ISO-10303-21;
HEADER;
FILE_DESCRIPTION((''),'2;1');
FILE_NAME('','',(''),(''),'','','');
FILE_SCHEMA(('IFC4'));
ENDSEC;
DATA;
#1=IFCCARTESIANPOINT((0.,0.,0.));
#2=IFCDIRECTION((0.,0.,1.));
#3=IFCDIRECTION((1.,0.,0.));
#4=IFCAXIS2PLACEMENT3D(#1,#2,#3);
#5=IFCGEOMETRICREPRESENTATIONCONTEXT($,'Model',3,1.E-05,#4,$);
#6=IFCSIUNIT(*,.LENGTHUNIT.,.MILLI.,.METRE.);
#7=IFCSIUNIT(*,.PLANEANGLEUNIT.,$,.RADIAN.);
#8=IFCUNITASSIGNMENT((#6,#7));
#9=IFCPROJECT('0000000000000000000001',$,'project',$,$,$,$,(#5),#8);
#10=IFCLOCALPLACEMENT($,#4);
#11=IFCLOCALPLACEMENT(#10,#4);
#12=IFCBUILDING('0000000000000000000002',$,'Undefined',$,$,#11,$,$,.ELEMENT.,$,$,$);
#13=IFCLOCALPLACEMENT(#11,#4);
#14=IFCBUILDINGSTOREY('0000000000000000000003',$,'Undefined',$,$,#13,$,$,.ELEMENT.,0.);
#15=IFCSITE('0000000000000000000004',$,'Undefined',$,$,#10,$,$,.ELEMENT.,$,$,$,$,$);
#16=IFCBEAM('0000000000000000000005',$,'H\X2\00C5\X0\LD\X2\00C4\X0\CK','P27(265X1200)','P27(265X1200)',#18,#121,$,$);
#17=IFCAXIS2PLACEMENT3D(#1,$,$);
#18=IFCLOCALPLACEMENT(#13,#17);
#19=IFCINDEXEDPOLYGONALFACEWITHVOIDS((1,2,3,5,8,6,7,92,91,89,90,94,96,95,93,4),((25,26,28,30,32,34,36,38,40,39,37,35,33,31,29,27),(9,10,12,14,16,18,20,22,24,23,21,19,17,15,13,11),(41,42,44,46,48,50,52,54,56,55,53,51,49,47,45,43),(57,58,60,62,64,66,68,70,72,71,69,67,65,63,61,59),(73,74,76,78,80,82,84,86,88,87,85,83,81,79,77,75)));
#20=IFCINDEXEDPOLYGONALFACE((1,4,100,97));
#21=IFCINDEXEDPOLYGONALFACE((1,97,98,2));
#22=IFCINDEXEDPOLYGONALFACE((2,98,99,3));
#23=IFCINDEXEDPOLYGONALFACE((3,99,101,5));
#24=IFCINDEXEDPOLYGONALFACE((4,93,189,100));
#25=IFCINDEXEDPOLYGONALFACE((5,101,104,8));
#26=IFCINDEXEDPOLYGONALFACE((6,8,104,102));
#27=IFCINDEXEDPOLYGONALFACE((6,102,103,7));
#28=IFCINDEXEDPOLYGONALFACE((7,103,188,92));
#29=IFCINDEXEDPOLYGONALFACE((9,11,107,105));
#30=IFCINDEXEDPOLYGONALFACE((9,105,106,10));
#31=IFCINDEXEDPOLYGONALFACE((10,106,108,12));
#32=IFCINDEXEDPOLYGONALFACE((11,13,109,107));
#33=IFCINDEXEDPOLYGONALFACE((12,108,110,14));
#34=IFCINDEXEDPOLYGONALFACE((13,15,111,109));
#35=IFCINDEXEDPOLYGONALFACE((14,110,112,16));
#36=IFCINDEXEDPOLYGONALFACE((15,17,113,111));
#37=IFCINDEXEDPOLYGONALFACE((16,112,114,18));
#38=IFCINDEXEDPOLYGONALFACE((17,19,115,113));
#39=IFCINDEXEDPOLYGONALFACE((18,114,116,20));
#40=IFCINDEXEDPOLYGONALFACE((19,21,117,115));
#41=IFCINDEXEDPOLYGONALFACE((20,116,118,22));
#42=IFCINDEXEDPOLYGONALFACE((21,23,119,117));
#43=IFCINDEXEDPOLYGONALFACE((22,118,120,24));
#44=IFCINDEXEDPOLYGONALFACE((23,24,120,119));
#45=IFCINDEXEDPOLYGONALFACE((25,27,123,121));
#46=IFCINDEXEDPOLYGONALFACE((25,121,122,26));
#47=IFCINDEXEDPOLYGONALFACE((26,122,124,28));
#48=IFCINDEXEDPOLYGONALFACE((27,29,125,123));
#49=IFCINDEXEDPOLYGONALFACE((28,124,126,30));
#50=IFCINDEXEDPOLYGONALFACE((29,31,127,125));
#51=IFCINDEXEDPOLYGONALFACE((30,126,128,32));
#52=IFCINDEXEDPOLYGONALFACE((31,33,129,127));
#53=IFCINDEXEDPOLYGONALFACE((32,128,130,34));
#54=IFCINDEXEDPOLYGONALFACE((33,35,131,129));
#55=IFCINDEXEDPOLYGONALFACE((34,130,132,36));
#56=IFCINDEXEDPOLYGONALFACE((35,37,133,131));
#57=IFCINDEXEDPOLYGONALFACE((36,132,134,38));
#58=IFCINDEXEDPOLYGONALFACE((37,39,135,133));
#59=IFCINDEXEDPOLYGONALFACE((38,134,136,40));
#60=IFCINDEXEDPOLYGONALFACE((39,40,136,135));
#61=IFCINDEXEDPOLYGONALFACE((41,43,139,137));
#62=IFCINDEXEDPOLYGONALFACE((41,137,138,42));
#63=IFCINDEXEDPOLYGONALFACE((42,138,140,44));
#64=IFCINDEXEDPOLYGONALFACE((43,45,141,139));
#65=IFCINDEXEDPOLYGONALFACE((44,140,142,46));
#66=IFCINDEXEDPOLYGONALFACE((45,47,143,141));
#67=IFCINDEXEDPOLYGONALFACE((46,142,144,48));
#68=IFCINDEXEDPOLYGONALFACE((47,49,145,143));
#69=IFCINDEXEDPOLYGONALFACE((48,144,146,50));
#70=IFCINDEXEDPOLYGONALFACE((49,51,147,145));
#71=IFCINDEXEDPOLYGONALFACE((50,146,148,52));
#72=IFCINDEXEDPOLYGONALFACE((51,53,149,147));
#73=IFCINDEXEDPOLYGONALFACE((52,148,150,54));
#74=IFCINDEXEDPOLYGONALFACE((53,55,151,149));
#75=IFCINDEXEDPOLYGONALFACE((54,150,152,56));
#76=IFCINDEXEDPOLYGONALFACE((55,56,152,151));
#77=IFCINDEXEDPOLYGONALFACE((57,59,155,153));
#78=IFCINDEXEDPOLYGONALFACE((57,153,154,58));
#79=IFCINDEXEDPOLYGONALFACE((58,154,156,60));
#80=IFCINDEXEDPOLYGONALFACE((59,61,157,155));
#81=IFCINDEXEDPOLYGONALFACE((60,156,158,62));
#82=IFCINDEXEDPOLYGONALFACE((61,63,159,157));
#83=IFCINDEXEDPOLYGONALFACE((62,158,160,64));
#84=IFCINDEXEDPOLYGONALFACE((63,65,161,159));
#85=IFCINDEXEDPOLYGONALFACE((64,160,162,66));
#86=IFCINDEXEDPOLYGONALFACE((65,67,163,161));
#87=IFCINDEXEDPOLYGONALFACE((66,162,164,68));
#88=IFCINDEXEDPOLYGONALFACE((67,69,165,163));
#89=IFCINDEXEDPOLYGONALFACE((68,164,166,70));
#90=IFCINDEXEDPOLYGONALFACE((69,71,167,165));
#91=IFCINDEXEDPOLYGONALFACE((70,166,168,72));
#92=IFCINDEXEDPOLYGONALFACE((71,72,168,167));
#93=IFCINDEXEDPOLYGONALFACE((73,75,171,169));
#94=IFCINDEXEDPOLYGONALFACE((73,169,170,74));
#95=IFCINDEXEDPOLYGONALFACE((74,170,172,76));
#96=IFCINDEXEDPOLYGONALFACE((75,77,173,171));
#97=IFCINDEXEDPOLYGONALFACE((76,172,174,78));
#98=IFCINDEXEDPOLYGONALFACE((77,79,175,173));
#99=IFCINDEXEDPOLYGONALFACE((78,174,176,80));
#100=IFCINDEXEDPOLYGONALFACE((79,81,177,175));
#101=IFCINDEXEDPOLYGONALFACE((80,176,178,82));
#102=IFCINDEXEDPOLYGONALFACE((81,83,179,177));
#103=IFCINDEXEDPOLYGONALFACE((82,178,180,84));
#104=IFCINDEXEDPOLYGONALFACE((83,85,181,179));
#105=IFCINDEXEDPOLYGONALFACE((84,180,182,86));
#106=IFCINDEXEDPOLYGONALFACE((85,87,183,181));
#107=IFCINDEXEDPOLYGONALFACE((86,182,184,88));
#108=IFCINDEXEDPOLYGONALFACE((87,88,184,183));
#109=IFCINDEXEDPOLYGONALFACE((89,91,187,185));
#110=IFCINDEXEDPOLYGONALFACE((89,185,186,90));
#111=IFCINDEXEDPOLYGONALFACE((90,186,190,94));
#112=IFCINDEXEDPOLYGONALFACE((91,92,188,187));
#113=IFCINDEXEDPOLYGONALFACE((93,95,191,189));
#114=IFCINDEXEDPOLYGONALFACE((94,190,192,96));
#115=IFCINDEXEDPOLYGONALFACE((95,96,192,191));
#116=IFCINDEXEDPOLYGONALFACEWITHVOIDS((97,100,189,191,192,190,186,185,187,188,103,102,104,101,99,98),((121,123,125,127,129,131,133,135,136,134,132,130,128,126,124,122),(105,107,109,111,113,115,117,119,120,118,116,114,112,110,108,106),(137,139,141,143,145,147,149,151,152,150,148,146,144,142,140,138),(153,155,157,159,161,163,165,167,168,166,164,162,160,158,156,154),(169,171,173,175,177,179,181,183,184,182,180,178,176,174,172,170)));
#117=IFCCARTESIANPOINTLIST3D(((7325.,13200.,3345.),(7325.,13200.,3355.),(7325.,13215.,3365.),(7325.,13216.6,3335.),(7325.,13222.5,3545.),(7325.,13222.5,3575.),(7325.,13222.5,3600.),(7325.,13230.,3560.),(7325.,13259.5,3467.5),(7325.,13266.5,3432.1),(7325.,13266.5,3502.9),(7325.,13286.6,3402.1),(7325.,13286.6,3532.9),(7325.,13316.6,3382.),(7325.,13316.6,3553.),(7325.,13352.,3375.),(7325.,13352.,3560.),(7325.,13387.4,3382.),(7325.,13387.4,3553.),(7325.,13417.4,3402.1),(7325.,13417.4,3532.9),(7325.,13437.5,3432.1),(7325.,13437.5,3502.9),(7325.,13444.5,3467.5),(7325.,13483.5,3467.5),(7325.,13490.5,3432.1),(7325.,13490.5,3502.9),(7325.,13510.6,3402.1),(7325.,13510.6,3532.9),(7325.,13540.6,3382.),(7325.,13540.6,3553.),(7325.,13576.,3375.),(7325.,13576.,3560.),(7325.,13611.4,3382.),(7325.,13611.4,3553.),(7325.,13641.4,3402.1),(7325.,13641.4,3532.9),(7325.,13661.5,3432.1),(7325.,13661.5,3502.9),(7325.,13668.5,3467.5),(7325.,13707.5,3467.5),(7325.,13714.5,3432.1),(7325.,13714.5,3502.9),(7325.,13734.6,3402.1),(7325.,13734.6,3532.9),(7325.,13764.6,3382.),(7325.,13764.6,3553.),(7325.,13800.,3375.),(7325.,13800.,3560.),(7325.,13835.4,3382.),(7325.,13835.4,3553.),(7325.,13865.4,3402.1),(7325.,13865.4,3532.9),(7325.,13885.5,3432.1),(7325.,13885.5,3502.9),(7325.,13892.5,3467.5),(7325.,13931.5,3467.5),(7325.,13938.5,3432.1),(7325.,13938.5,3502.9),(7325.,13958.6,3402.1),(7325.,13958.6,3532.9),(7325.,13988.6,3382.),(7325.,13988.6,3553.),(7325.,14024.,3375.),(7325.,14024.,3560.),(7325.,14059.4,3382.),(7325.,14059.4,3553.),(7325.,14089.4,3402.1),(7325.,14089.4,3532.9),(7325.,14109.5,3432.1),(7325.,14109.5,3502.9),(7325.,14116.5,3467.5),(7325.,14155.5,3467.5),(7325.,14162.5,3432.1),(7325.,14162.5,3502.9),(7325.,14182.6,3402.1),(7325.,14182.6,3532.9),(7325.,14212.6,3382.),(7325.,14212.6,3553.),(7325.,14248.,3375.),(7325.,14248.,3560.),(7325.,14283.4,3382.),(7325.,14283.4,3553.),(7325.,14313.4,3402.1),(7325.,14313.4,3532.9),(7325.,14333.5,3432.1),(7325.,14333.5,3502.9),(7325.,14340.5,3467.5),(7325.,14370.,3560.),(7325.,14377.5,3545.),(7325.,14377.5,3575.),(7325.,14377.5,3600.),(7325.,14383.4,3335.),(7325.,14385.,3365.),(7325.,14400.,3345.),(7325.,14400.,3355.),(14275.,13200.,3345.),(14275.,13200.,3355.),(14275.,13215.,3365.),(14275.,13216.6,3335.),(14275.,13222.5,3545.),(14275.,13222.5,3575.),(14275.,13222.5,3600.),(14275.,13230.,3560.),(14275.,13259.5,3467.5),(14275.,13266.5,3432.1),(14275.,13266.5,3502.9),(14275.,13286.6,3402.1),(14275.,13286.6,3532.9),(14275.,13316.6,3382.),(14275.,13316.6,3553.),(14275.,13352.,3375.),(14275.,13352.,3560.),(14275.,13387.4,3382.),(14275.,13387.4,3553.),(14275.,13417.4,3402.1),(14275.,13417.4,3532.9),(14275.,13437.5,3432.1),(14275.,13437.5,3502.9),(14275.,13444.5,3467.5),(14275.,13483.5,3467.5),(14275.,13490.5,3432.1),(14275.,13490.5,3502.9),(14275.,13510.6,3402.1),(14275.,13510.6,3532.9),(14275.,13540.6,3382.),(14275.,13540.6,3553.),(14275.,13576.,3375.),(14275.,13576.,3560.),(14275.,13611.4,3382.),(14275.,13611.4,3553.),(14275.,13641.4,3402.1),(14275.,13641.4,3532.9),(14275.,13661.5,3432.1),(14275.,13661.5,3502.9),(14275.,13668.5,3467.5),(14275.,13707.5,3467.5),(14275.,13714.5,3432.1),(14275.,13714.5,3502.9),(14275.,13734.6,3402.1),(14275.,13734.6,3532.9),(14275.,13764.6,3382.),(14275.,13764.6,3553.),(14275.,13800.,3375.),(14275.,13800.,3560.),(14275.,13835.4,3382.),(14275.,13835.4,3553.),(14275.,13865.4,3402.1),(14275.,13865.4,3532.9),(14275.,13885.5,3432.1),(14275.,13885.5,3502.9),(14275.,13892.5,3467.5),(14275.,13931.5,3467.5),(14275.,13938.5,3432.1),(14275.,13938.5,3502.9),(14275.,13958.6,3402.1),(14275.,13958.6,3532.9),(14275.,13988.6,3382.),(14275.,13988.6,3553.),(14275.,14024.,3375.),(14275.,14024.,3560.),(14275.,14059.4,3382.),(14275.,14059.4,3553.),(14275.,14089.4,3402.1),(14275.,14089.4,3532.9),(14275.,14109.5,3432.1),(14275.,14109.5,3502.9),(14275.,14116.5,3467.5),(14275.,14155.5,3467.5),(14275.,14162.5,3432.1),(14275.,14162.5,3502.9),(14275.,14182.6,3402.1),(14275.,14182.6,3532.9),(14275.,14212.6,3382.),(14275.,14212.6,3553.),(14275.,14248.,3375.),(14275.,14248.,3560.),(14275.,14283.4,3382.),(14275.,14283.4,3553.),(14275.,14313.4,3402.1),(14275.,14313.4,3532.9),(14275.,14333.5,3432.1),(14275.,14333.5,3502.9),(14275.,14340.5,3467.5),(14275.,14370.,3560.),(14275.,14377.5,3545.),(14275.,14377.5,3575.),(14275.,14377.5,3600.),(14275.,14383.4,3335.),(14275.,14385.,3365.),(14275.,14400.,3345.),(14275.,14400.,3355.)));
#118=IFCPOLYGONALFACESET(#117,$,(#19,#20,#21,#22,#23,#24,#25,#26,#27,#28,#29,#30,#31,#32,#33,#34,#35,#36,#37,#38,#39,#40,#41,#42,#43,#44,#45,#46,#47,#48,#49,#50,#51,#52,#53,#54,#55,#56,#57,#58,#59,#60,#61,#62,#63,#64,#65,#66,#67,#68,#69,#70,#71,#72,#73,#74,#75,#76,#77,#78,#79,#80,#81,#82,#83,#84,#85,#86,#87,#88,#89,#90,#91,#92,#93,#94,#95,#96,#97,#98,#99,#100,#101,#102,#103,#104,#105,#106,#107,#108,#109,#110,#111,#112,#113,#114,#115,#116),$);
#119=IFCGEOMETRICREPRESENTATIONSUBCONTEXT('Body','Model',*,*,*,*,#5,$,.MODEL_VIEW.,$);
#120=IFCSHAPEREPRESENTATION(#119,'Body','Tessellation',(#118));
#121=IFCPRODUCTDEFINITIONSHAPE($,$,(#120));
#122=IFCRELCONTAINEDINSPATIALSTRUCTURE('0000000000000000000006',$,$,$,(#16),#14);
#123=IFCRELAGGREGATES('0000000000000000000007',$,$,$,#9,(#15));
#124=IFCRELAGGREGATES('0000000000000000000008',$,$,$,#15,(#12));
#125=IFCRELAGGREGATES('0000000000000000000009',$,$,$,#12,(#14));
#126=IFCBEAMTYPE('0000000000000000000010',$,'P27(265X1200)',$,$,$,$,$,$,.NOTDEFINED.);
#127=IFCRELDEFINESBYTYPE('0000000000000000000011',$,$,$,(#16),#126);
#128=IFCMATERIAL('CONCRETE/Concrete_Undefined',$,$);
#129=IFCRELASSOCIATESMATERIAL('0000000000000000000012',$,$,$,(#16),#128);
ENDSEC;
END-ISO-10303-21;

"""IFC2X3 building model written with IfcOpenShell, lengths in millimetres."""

from ifc_helpers import new_model, si_unit, frame, origin_with_axes, place, context, subcontext, project, spatial, polyline, outline, extrude, material, type_object, element, save


model = new_model("IFC2X3")

# Units and contexts
model_context = context("Model", 3, precision=1e-05, world=origin_with_axes())
body_context = subcontext(model_context, "Body", "Model", "MODEL_VIEW")
ifc_project = project(units=[si_unit("LENGTHUNIT", "METRE", prefix="MILLI"), si_unit("PLANEANGLEUNIT", "RADIAN")], contexts=[model_context])

# Site, building, storey
site_placement = place(None, origin_with_axes())
site = spatial("IfcSite", under=ifc_project, at=site_placement, Name="Undefined", CompositionType="ELEMENT")
building_placement = place(site_placement, origin_with_axes())
building = spatial("IfcBuilding", under=site, at=building_placement, Name="Undefined", CompositionType="ELEMENT")
storey_placement = place(building_placement, origin_with_axes())
storey = spatial("IfcBuildingStorey", under=building, at=storey_placement, Name="Undefined", CompositionType="ELEMENT", Elevation=0.0)

# Beam
ifc_material_1 = material(Name="CONCRETE/Concrete_Undefined")
beam_type_1 = type_object("IfcBeamType", Name="P27(265X1200)", PredefinedType="NOTDEFINED")
beam_1_placement = place(storey_placement, frame((7325.0, 13800.0, 3467.5), z_axis=(0.0, 0.0, 1.0), x_axis=(1.0, 0.0, 0.0)))
element("IfcBeam", 1, at=beam_1_placement, inside=storey, type_object=beam_type_1, material=ifc_material_1, Name="HÅLDÄCK", Description="P27(265X1200)", ObjectType="P27(265X1200)", context=body_context, shape_type="SweptSolid", body=[
    extrude(outline(polyline([(-583.4, -132.5), (-600.0, -122.5), (-600.0, -112.5), (-585.0, -102.5), (-577.5, 77.5), (-570.0, 92.5), (-577.5, 107.5), (-577.5, 132.5), (577.5, 132.5), (577.5, 107.5), (570.0, 92.5), (577.5, 77.5), (585.0, -102.5), (600.0, -112.5), (600.0, -122.5), (583.4, -132.5), (-583.4, -132.5)]), holes=[polyline([(-513.4, 65.4), (-533.5, 35.4), (-540.5, 0.0), (-533.5, -35.4), (-513.4, -65.4), (-483.4, -85.5), (-448.0, -92.5), (-412.6, -85.5), (-382.6, -65.4), (-362.5, -35.4), (-355.5, 0.0), (-362.5, 35.4), (-382.6, 65.4), (-412.6, 85.5), (-448.0, 92.5), (-483.4, 85.5), (-513.4, 65.4)]), polyline([(-289.4, 65.4), (-309.5, 35.4), (-316.5, 0.0), (-309.5, -35.4), (-289.4, -65.4), (-259.4, -85.5), (-224.0, -92.5), (-188.6, -85.5), (-158.6, -65.4), (-138.5, -35.4), (-131.5, 0.0), (-138.5, 35.4), (-158.6, 65.4), (-188.6, 85.5), (-224.0, 92.5), (-259.4, 85.5), (-289.4, 65.4)]), polyline([(-65.4, 65.4), (-85.5, 35.4), (-92.5, 0.0), (-85.5, -35.4), (-65.4, -65.4), (-35.4, -85.5), (0.0, -92.5), (35.4, -85.5), (65.4, -65.4), (85.5, -35.4), (92.5, 0.0), (85.5, 35.4), (65.4, 65.4), (35.4, 85.5), (0.0, 92.5), (-35.4, 85.5), (-65.4, 65.4)]), polyline([(158.6, 65.4), (138.5, 35.4), (131.5, 0.0), (138.5, -35.4), (158.6, -65.4), (188.6, -85.5), (224.0, -92.5), (259.4, -85.5), (289.4, -65.4), (309.5, -35.4), (316.5, 0.0), (309.5, 35.4), (289.4, 65.4), (259.4, 85.5), (224.0, 92.5), (188.6, 85.5), (158.6, 65.4)]), polyline([(382.6, 65.4), (362.5, 35.4), (355.5, 0.0), (362.5, -35.4), (382.6, -65.4), (412.6, -85.5), (448.0, -92.5), (483.4, -85.5), (513.4, -65.4), (533.5, -35.4), (540.5, 0.0), (533.5, 35.4), (513.4, 65.4), (483.4, 85.5), (448.0, 92.5), (412.6, 85.5), (382.6, 65.4)])]), frame((6950.0, 0.0, 0.0), z_axis=(-1.0, 0.0, 0.0), x_axis=(0.0, -1.0, 0.0)), (0.0, 0.0, 1.0), 6950.0),
])

save(model, "model.ifc")
